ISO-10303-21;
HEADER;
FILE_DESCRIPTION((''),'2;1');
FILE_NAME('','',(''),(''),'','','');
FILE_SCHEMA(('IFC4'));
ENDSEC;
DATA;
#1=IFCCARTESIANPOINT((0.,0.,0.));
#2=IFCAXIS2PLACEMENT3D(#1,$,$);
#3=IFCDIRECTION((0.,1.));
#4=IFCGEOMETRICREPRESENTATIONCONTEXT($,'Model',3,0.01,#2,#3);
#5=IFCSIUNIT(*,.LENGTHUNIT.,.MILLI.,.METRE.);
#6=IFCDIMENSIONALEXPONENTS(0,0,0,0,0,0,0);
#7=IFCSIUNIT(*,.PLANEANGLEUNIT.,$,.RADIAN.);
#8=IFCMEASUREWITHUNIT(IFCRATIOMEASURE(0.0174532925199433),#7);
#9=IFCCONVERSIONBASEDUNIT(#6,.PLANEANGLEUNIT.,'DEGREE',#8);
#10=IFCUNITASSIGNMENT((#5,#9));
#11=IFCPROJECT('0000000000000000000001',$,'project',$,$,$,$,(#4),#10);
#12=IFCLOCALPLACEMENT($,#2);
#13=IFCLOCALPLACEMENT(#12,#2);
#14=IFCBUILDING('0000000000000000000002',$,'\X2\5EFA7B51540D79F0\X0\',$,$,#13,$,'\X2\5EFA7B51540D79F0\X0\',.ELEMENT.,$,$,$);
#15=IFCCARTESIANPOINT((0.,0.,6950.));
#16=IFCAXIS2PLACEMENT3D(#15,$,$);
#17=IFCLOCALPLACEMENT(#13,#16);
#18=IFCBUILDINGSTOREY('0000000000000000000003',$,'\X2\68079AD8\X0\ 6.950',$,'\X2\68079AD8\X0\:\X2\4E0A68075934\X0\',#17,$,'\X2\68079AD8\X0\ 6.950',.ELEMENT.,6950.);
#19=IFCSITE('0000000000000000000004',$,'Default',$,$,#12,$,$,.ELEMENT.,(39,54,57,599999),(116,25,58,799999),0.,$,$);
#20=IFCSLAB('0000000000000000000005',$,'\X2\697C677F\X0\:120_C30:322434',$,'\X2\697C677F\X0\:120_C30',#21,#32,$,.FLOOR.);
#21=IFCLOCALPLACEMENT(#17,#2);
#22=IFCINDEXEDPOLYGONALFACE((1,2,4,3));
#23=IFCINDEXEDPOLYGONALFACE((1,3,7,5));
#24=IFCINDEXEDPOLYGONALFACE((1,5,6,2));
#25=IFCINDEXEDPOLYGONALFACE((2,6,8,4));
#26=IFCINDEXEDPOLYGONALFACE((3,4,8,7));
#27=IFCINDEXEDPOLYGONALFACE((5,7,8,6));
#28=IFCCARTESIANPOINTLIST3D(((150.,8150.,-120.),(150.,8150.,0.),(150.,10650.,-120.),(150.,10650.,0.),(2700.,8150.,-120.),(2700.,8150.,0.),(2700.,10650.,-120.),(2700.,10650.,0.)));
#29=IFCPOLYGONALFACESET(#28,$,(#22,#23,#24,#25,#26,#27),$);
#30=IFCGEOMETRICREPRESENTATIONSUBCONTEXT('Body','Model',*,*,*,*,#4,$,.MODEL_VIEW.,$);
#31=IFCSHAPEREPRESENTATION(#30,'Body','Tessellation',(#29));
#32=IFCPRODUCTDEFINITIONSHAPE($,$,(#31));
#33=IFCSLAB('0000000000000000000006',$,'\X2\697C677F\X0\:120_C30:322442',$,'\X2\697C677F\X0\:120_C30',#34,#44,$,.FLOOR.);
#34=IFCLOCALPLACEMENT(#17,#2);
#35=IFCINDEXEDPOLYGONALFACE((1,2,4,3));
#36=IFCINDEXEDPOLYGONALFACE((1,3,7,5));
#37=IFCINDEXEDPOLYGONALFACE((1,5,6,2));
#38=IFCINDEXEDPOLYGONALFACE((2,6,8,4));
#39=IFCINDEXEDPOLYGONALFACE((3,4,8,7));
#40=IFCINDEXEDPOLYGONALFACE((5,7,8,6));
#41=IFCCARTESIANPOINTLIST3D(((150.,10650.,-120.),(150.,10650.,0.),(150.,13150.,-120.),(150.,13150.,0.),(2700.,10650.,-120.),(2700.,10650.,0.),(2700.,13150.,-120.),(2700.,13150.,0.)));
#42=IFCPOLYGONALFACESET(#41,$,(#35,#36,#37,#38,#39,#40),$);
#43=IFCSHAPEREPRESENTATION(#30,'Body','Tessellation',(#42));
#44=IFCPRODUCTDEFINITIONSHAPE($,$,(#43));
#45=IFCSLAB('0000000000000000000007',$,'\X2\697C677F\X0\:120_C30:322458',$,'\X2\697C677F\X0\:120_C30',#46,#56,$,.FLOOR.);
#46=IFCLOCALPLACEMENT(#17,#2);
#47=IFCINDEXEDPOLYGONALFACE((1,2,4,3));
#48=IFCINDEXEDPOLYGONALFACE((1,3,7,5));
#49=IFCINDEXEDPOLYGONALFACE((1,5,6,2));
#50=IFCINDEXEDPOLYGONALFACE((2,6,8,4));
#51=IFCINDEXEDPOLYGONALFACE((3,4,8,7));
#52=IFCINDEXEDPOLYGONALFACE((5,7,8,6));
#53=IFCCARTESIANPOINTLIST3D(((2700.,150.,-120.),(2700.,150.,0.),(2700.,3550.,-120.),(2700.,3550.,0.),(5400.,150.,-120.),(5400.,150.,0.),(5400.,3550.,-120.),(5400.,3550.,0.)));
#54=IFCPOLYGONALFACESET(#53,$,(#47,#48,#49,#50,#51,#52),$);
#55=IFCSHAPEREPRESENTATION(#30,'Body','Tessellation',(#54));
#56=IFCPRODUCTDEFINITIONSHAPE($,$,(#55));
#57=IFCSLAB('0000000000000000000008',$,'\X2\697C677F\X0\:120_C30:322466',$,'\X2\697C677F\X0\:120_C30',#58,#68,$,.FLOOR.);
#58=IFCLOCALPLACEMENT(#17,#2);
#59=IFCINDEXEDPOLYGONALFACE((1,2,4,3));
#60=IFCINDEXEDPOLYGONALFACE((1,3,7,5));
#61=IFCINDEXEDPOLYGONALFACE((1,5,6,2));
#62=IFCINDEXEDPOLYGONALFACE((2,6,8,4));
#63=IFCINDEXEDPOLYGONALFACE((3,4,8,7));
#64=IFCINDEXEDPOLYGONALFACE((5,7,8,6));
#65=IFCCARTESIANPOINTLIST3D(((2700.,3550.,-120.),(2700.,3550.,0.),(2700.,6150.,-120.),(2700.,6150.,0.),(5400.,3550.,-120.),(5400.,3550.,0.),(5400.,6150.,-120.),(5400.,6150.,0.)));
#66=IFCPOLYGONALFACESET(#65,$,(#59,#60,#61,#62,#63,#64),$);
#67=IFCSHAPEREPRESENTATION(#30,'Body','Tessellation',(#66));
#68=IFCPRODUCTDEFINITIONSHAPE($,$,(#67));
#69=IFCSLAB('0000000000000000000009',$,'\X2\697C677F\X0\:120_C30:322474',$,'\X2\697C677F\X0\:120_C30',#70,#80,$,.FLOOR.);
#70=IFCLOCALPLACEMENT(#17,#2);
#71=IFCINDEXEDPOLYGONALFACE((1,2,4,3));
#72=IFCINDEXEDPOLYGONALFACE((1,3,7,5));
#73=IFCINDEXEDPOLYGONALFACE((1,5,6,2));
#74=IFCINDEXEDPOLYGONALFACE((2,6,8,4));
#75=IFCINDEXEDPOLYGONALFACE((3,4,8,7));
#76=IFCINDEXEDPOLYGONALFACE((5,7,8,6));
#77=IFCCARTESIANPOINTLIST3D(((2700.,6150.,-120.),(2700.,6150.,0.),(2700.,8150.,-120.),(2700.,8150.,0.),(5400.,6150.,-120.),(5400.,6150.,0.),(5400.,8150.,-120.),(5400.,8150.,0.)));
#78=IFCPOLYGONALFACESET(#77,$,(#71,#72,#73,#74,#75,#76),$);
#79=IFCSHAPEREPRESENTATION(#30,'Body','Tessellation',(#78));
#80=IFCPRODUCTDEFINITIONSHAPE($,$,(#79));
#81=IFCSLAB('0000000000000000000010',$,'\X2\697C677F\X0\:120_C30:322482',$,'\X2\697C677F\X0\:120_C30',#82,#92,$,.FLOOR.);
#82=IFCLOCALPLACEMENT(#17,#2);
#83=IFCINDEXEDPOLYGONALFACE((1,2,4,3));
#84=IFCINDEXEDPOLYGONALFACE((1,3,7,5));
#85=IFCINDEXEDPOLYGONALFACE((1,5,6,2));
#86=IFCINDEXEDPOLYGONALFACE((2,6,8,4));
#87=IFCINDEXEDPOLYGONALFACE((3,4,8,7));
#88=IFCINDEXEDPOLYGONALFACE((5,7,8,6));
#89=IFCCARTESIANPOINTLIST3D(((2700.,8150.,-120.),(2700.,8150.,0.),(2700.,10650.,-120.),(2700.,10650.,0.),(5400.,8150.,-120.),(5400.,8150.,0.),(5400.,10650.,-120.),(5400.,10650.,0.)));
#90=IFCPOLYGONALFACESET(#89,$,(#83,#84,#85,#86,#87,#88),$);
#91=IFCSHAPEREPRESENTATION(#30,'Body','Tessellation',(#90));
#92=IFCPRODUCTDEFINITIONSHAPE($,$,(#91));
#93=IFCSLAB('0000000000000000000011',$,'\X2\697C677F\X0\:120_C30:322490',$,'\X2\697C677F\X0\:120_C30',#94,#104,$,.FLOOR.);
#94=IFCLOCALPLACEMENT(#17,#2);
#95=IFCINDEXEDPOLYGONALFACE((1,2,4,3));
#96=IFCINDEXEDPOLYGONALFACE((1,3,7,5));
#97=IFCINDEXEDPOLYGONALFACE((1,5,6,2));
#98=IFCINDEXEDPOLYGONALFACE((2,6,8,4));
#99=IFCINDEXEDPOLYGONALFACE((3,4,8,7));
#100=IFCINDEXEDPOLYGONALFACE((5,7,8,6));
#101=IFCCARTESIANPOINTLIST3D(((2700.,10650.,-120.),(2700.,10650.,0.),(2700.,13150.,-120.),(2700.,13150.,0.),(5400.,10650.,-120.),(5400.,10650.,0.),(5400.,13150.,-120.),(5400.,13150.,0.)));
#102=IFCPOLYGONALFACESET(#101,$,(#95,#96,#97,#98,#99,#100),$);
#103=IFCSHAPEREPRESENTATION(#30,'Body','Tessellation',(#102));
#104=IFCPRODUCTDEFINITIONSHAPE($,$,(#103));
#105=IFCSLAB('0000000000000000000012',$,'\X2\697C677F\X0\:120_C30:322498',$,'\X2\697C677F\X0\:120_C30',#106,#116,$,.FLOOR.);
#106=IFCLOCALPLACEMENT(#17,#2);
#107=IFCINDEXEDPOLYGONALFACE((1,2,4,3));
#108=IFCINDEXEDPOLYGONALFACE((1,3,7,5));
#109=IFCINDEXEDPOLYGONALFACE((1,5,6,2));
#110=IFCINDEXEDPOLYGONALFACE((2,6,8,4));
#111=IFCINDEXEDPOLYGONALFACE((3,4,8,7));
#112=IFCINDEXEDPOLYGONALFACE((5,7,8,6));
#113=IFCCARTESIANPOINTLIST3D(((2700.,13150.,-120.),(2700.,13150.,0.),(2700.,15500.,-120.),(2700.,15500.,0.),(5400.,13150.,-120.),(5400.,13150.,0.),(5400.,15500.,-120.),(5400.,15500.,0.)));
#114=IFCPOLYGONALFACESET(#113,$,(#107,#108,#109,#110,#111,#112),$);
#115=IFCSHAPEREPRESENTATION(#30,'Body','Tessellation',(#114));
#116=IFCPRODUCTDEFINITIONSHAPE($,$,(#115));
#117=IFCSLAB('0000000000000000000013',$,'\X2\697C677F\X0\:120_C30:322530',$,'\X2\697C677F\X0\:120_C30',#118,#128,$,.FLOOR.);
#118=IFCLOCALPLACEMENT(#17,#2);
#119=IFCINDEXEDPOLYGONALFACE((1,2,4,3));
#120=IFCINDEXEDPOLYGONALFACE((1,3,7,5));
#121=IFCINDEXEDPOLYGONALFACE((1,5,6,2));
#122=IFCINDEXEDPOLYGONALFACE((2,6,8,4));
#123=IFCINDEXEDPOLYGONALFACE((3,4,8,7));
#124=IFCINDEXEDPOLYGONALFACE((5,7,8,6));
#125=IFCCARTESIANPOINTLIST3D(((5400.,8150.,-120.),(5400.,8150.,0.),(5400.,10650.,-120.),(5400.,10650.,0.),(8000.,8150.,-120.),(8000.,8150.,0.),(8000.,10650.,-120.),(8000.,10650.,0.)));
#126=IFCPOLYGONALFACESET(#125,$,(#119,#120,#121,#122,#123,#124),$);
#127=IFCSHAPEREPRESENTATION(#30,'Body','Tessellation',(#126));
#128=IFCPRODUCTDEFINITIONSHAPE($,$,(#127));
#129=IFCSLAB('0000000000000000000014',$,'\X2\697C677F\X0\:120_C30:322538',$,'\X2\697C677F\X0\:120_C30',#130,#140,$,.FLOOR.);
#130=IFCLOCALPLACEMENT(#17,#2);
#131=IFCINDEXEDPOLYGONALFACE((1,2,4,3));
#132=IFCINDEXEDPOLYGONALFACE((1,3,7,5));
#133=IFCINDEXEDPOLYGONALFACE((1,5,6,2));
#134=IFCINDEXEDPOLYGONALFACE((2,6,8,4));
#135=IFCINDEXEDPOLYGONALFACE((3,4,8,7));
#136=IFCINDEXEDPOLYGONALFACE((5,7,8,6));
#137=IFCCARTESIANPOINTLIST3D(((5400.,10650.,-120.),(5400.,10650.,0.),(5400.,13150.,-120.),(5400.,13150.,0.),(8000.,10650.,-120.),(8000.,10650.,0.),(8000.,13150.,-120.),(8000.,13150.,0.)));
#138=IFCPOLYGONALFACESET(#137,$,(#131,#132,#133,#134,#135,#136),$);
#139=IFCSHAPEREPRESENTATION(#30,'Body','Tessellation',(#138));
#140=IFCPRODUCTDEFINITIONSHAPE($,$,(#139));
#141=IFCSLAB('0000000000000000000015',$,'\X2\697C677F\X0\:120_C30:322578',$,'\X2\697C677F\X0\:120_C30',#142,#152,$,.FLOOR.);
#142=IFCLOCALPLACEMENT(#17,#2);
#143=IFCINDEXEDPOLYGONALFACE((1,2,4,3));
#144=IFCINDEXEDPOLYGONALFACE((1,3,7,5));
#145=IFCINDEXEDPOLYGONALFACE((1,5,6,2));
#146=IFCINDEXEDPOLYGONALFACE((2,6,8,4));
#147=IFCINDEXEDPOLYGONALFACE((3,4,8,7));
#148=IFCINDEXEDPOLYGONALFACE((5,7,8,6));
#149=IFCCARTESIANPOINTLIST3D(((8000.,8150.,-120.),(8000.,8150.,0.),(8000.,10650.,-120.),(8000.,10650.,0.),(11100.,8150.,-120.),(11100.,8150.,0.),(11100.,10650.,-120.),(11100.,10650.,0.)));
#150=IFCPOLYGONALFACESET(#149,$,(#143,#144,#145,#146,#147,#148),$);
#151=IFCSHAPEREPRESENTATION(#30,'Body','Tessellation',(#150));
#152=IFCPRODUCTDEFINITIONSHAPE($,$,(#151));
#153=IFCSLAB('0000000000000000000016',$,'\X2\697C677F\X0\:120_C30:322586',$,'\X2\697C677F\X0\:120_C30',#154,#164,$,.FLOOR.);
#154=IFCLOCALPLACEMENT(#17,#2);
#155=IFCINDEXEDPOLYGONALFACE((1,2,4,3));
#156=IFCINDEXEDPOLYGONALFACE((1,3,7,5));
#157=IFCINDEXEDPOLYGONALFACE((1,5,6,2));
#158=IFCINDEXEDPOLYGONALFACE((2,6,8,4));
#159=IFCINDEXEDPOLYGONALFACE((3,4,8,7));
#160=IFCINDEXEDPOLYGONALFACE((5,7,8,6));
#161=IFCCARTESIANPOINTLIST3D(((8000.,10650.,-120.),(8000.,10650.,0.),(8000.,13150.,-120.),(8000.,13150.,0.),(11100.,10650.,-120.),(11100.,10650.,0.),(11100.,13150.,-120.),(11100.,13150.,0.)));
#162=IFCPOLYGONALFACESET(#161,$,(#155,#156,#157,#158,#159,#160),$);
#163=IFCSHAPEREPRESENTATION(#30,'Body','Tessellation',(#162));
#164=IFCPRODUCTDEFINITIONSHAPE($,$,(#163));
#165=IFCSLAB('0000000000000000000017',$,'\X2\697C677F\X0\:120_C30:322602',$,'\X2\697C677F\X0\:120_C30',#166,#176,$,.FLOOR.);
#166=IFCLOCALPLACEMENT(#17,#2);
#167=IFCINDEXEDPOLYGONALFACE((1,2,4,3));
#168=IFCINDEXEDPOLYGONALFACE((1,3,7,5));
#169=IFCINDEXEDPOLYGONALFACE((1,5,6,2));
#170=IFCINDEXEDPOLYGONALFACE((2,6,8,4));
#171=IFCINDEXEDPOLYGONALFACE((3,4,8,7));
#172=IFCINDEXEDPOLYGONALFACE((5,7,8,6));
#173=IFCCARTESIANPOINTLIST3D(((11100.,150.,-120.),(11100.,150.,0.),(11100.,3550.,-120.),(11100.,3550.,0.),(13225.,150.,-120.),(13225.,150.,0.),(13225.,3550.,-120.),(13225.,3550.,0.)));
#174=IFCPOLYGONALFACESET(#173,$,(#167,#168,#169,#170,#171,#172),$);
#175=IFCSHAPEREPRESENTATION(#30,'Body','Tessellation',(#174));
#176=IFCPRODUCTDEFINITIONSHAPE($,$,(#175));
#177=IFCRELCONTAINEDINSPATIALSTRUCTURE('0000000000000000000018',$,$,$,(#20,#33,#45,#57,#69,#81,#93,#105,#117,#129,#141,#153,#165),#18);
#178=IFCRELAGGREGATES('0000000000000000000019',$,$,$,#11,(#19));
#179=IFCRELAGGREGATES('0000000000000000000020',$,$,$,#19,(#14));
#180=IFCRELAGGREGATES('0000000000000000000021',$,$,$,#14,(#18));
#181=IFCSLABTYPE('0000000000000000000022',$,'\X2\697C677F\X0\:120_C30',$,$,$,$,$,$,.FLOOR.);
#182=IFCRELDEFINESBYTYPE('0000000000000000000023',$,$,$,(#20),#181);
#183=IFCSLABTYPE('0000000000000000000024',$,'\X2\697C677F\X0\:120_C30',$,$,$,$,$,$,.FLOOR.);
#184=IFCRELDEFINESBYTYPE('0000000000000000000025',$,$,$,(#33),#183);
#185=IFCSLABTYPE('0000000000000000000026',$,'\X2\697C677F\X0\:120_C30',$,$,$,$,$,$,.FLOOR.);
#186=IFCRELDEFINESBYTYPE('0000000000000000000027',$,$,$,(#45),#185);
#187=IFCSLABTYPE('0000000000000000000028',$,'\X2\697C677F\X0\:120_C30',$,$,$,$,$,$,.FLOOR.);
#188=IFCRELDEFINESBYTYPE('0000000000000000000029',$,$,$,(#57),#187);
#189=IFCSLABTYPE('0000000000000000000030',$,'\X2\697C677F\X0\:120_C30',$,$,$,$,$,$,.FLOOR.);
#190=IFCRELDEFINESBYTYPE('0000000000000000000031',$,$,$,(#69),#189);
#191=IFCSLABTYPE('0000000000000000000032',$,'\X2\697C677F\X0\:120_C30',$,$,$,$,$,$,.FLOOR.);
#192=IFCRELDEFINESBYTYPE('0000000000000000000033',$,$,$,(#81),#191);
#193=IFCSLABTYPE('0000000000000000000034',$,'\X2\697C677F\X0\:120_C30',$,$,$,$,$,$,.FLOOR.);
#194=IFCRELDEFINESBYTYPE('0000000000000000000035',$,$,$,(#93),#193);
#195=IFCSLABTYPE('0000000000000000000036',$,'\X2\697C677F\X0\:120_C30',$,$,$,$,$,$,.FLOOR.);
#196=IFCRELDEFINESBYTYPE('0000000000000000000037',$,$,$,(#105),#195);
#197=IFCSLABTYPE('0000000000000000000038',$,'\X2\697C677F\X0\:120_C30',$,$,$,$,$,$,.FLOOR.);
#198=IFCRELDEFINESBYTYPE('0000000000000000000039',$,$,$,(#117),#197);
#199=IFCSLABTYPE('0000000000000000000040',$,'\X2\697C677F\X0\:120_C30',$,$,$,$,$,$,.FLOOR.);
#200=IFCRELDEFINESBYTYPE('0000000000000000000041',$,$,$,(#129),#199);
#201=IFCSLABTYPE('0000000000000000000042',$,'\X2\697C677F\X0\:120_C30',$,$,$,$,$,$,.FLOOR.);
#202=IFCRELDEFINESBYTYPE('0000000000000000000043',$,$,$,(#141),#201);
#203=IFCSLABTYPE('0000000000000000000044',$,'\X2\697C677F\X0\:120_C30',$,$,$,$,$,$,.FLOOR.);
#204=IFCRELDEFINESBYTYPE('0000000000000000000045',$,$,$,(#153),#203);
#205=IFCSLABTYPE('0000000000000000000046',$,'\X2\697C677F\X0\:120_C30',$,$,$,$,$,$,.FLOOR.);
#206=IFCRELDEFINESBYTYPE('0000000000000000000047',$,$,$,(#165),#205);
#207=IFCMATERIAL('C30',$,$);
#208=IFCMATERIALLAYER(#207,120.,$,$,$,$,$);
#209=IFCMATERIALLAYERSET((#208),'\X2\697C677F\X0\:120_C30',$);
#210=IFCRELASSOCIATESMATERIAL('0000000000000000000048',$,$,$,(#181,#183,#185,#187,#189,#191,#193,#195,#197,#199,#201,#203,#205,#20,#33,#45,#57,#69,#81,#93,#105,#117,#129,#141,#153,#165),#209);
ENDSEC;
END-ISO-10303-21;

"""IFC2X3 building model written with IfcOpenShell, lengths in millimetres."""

from ifc_helpers import new_model, entity, si_unit, converted_unit, direction, frame, frame_2d, origin, origin_2d_with_axis, place, context, subcontext, project, spatial, rectangle, extrude, material, layer, layer_set, layer_usage, type_object, element, save


model = new_model("IFC2X3")

# Units and contexts
model_context = context("Model", 3, precision=0.01, world=origin(), true_north=direction((0.0, 1.0)))
body_context = subcontext(model_context, "Body", "Model", "MODEL_VIEW")
ifc_project = project(units=[si_unit("LENGTHUNIT", "METRE", prefix="MILLI"), converted_unit("PLANEANGLEUNIT", "DEGREE", entity("IfcRatioMeasure", 0.0174532925199433), si_unit("PLANEANGLEUNIT", "RADIAN"), dimensions=[0, 0, 0, 0, 0, 0, 0])], contexts=[model_context])

# Site, building, storey
site_placement = place(None, origin())
site = spatial("IfcSite", under=ifc_project, at=site_placement, Name="Default", CompositionType="ELEMENT", RefLatitude=(39, 54, 57, 599999), RefLongitude=(116, 25, 58, 799999), RefElevation=0.0)
building_placement = place(site_placement, origin())
building = spatial("IfcBuilding", under=site, at=building_placement, Name="建筑名称", LongName="建筑名称", CompositionType="ELEMENT")
storey_placement = place(building_placement, frame((0.0, 0.0, 6950.0)))
storey = spatial("IfcBuildingStorey", under=building, at=storey_placement, Name="标高 6.950", ObjectType="标高:上标头", LongName="标高 6.950", CompositionType="ELEMENT", Elevation=6950.0)

# Slabs
ifc_material = material(Name="C30")
ifc_layer = layer(ifc_material, 120.0)
ifc_layer_set = layer_set([ifc_layer], Name="楼板:120_C30")
ifc_layer_usage_1 = layer_usage(ifc_layer_set, "AXIS3", "POSITIVE", 0.0)
slab_type_1 = type_object("IfcSlabType", Name="楼板:120_C30", PredefinedType="FLOOR", material=ifc_layer_set)
slab_1_placement = place(storey_placement, origin())
element("IfcSlab", 1, at=slab_1_placement, inside=storey, type_object=slab_type_1, material=ifc_layer_usage_1, Name="楼板:120_C30:322434", ObjectType="楼板:120_C30", PredefinedType="FLOOR", context=body_context, shape_type="SweptSolid", body=[
    extrude(rectangle(XDim=2500.0, YDim=2550.0, at=frame_2d((0.0, 0.0), x_axis=(1.0, 0.0))), frame((1425.0, 9400.0, 0.0), z_axis=(0.0, 0.0, -1.0), x_axis=(0.0, 1.0, 0.0)), (0.0, 0.0, 1.0), 120.0),
])
ifc_layer_usage_2 = layer_usage(ifc_layer_set, "AXIS3", "POSITIVE", 0.0)
slab_type_2 = type_object("IfcSlabType", Name="楼板:120_C30", PredefinedType="FLOOR", material=ifc_layer_set)
slab_2_placement = place(storey_placement, origin())
element("IfcSlab", 2, at=slab_2_placement, inside=storey, type_object=slab_type_2, material=ifc_layer_usage_2, Name="楼板:120_C30:322442", ObjectType="楼板:120_C30", PredefinedType="FLOOR", context=body_context, shape_type="SweptSolid", body=[
    extrude(rectangle(XDim=2500.0, YDim=2550.0, at=origin_2d_with_axis()), frame((1425.0, 11900.0, 0.0), z_axis=(0.0, 0.0, -1.0), x_axis=(0.0, 1.0, 0.0)), (0.0, 0.0, 1.0), 120.0),
])
ifc_layer_usage_3 = layer_usage(ifc_layer_set, "AXIS3", "POSITIVE", 0.0)
slab_type_3 = type_object("IfcSlabType", Name="楼板:120_C30", PredefinedType="FLOOR", material=ifc_layer_set)
slab_3_placement = place(storey_placement, origin())
element("IfcSlab", 3, at=slab_3_placement, inside=storey, type_object=slab_type_3, material=ifc_layer_usage_3, Name="楼板:120_C30:322458", ObjectType="楼板:120_C30", PredefinedType="FLOOR", context=body_context, shape_type="SweptSolid", body=[
    extrude(rectangle(XDim=3400.0, YDim=2700.0, at=origin_2d_with_axis()), frame((4050.0, 1850.0, 0.0), z_axis=(0.0, 0.0, -1.0), x_axis=(0.0, 1.0, 0.0)), (0.0, 0.0, 1.0), 120.0),
])
ifc_layer_usage_4 = layer_usage(ifc_layer_set, "AXIS3", "POSITIVE", 0.0)
slab_type_4 = type_object("IfcSlabType", Name="楼板:120_C30", PredefinedType="FLOOR", material=ifc_layer_set)
slab_4_placement = place(storey_placement, origin())
element("IfcSlab", 4, at=slab_4_placement, inside=storey, type_object=slab_type_4, material=ifc_layer_usage_4, Name="楼板:120_C30:322466", ObjectType="楼板:120_C30", PredefinedType="FLOOR", context=body_context, shape_type="SweptSolid", body=[
    extrude(rectangle(XDim=2600.0, YDim=2700.0, at=frame_2d((0.0, 0.0), x_axis=(1.0, 0.0))), frame((4050.0, 4850.0, 0.0), z_axis=(0.0, 0.0, -1.0), x_axis=(0.0, 1.0, 0.0)), (0.0, 0.0, 1.0), 120.0),
])
ifc_layer_usage_5 = layer_usage(ifc_layer_set, "AXIS3", "POSITIVE", 0.0)
slab_type_5 = type_object("IfcSlabType", Name="楼板:120_C30", PredefinedType="FLOOR", material=ifc_layer_set)
slab_5_placement = place(storey_placement, origin())
element("IfcSlab", 5, at=slab_5_placement, inside=storey, type_object=slab_type_5, material=ifc_layer_usage_5, Name="楼板:120_C30:322474", ObjectType="楼板:120_C30", PredefinedType="FLOOR", context=body_context, shape_type="SweptSolid", body=[
    extrude(rectangle(XDim=2000.0, YDim=2700.0, at=origin_2d_with_axis()), frame((4050.0, 7150.0, 0.0), z_axis=(0.0, 0.0, -1.0), x_axis=(0.0, 1.0, 0.0)), (0.0, 0.0, 1.0), 120.0),
])
ifc_layer_usage_6 = layer_usage(ifc_layer_set, "AXIS3", "POSITIVE", 0.0)
slab_type_6 = type_object("IfcSlabType", Name="楼板:120_C30", PredefinedType="FLOOR", material=ifc_layer_set)
slab_6_placement = place(storey_placement, origin())
element("IfcSlab", 6, at=slab_6_placement, inside=storey, type_object=slab_type_6, material=ifc_layer_usage_6, Name="楼板:120_C30:322482", ObjectType="楼板:120_C30", PredefinedType="FLOOR", context=body_context, shape_type="SweptSolid", body=[
    extrude(rectangle(XDim=2500.0, YDim=2700.0, at=frame_2d((0.0, 0.0), x_axis=(1.0, 0.0))), frame((4050.0, 9400.0, 0.0), z_axis=(0.0, 0.0, -1.0), x_axis=(0.0, 1.0, 0.0)), (0.0, 0.0, 1.0), 120.0),
])
ifc_layer_usage_7 = layer_usage(ifc_layer_set, "AXIS3", "POSITIVE", 0.0)
slab_type_7 = type_object("IfcSlabType", Name="楼板:120_C30", PredefinedType="FLOOR", material=ifc_layer_set)
slab_7_placement = place(storey_placement, origin())
element("IfcSlab", 7, at=slab_7_placement, inside=storey, type_object=slab_type_7, material=ifc_layer_usage_7, Name="楼板:120_C30:322490", ObjectType="楼板:120_C30", PredefinedType="FLOOR", context=body_context, shape_type="SweptSolid", body=[
    extrude(rectangle(XDim=2500.0, YDim=2700.0, at=origin_2d_with_axis()), frame((4050.0, 11900.0, 0.0), z_axis=(0.0, 0.0, -1.0), x_axis=(0.0, 1.0, 0.0)), (0.0, 0.0, 1.0), 120.0),
])
ifc_layer_usage_8 = layer_usage(ifc_layer_set, "AXIS3", "POSITIVE", 0.0)
slab_type_8 = type_object("IfcSlabType", Name="楼板:120_C30", PredefinedType="FLOOR", material=ifc_layer_set)
slab_8_placement = place(storey_placement, origin())
element("IfcSlab", 8, at=slab_8_placement, inside=storey, type_object=slab_type_8, material=ifc_layer_usage_8, Name="楼板:120_C30:322498", ObjectType="楼板:120_C30", PredefinedType="FLOOR", context=body_context, shape_type="SweptSolid", body=[
    extrude(rectangle(XDim=2350.0, YDim=2700.0, at=frame_2d((0.0, 0.0), x_axis=(1.0, 0.0))), frame((4050.0, 14325.0, 0.0), z_axis=(0.0, 0.0, -1.0), x_axis=(0.0, 1.0, 0.0)), (0.0, 0.0, 1.0), 120.0),
])
ifc_layer_usage_9 = layer_usage(ifc_layer_set, "AXIS3", "POSITIVE", 0.0)
slab_type_9 = type_object("IfcSlabType", Name="楼板:120_C30", PredefinedType="FLOOR", material=ifc_layer_set)
slab_9_placement = place(storey_placement, origin())
element("IfcSlab", 9, at=slab_9_placement, inside=storey, type_object=slab_type_9, material=ifc_layer_usage_9, Name="楼板:120_C30:322530", ObjectType="楼板:120_C30", PredefinedType="FLOOR", context=body_context, shape_type="SweptSolid", body=[
    extrude(rectangle(XDim=2500.0, YDim=2600.0, at=frame_2d((0.0, 0.0), x_axis=(1.0, 0.0))), frame((6700.0, 9400.0, 0.0), z_axis=(0.0, 0.0, -1.0), x_axis=(0.0, 1.0, 0.0)), (0.0, 0.0, 1.0), 120.0),
])
ifc_layer_usage_10 = layer_usage(ifc_layer_set, "AXIS3", "POSITIVE", 0.0)
slab_type_10 = type_object("IfcSlabType", Name="楼板:120_C30", PredefinedType="FLOOR", material=ifc_layer_set)
slab_10_placement = place(storey_placement, origin())
element("IfcSlab", 10, at=slab_10_placement, inside=storey, type_object=slab_type_10, material=ifc_layer_usage_10, Name="楼板:120_C30:322538", ObjectType="楼板:120_C30", PredefinedType="FLOOR", context=body_context, shape_type="SweptSolid", body=[
    extrude(rectangle(XDim=2500.0, YDim=2600.0, at=origin_2d_with_axis()), frame((6700.0, 11900.0, 0.0), z_axis=(0.0, 0.0, -1.0), x_axis=(0.0, 1.0, 0.0)), (0.0, 0.0, 1.0), 120.0),
])
ifc_layer_usage_11 = layer_usage(ifc_layer_set, "AXIS3", "POSITIVE", 0.0)
slab_type_11 = type_object("IfcSlabType", Name="楼板:120_C30", PredefinedType="FLOOR", material=ifc_layer_set)
slab_11_placement = place(storey_placement, origin())
element("IfcSlab", 11, at=slab_11_placement, inside=storey, type_object=slab_type_11, material=ifc_layer_usage_11, Name="楼板:120_C30:322578", ObjectType="楼板:120_C30", PredefinedType="FLOOR", context=body_context, shape_type="SweptSolid", body=[
    extrude(rectangle(XDim=2500.0, YDim=3100.0, at=frame_2d((0.0, 0.0), x_axis=(1.0, 0.0))), frame((9550.0, 9400.0, 0.0), z_axis=(0.0, 0.0, -1.0), x_axis=(0.0, 1.0, 0.0)), (0.0, 0.0, 1.0), 120.0),
])
ifc_layer_usage_12 = layer_usage(ifc_layer_set, "AXIS3", "POSITIVE", 0.0)
slab_type_12 = type_object("IfcSlabType", Name="楼板:120_C30", PredefinedType="FLOOR", material=ifc_layer_set)
slab_12_placement = place(storey_placement, origin())
element("IfcSlab", 12, at=slab_12_placement, inside=storey, type_object=slab_type_12, material=ifc_layer_usage_12, Name="楼板:120_C30:322586", ObjectType="楼板:120_C30", PredefinedType="FLOOR", context=body_context, shape_type="SweptSolid", body=[
    extrude(rectangle(XDim=2500.0, YDim=3100.0, at=frame_2d((0.0, 0.0), x_axis=(1.0, 0.0))), frame((9550.0, 11900.0, 0.0), z_axis=(0.0, 0.0, -1.0), x_axis=(0.0, 1.0, 0.0)), (0.0, 0.0, 1.0), 120.0),
])
ifc_layer_usage_13 = layer_usage(ifc_layer_set, "AXIS3", "POSITIVE", 0.0)
slab_type_13 = type_object("IfcSlabType", Name="楼板:120_C30", PredefinedType="FLOOR", material=ifc_layer_set)
slab_13_placement = place(storey_placement, origin())
element("IfcSlab", 13, at=slab_13_placement, inside=storey, type_object=slab_type_13, material=ifc_layer_usage_13, Name="楼板:120_C30:322602", ObjectType="楼板:120_C30", PredefinedType="FLOOR", context=body_context, shape_type="SweptSolid", body=[
    extrude(rectangle(XDim=3400.0, YDim=2125.0, at=frame_2d((0.0, 0.0), x_axis=(1.0, 0.0))), frame((12162.5, 1850.0, 0.0), z_axis=(0.0, 0.0, -1.0), x_axis=(0.0, 1.0, 0.0)), (0.0, 0.0, 1.0), 120.0),
])

save(model, "model.ifc")
